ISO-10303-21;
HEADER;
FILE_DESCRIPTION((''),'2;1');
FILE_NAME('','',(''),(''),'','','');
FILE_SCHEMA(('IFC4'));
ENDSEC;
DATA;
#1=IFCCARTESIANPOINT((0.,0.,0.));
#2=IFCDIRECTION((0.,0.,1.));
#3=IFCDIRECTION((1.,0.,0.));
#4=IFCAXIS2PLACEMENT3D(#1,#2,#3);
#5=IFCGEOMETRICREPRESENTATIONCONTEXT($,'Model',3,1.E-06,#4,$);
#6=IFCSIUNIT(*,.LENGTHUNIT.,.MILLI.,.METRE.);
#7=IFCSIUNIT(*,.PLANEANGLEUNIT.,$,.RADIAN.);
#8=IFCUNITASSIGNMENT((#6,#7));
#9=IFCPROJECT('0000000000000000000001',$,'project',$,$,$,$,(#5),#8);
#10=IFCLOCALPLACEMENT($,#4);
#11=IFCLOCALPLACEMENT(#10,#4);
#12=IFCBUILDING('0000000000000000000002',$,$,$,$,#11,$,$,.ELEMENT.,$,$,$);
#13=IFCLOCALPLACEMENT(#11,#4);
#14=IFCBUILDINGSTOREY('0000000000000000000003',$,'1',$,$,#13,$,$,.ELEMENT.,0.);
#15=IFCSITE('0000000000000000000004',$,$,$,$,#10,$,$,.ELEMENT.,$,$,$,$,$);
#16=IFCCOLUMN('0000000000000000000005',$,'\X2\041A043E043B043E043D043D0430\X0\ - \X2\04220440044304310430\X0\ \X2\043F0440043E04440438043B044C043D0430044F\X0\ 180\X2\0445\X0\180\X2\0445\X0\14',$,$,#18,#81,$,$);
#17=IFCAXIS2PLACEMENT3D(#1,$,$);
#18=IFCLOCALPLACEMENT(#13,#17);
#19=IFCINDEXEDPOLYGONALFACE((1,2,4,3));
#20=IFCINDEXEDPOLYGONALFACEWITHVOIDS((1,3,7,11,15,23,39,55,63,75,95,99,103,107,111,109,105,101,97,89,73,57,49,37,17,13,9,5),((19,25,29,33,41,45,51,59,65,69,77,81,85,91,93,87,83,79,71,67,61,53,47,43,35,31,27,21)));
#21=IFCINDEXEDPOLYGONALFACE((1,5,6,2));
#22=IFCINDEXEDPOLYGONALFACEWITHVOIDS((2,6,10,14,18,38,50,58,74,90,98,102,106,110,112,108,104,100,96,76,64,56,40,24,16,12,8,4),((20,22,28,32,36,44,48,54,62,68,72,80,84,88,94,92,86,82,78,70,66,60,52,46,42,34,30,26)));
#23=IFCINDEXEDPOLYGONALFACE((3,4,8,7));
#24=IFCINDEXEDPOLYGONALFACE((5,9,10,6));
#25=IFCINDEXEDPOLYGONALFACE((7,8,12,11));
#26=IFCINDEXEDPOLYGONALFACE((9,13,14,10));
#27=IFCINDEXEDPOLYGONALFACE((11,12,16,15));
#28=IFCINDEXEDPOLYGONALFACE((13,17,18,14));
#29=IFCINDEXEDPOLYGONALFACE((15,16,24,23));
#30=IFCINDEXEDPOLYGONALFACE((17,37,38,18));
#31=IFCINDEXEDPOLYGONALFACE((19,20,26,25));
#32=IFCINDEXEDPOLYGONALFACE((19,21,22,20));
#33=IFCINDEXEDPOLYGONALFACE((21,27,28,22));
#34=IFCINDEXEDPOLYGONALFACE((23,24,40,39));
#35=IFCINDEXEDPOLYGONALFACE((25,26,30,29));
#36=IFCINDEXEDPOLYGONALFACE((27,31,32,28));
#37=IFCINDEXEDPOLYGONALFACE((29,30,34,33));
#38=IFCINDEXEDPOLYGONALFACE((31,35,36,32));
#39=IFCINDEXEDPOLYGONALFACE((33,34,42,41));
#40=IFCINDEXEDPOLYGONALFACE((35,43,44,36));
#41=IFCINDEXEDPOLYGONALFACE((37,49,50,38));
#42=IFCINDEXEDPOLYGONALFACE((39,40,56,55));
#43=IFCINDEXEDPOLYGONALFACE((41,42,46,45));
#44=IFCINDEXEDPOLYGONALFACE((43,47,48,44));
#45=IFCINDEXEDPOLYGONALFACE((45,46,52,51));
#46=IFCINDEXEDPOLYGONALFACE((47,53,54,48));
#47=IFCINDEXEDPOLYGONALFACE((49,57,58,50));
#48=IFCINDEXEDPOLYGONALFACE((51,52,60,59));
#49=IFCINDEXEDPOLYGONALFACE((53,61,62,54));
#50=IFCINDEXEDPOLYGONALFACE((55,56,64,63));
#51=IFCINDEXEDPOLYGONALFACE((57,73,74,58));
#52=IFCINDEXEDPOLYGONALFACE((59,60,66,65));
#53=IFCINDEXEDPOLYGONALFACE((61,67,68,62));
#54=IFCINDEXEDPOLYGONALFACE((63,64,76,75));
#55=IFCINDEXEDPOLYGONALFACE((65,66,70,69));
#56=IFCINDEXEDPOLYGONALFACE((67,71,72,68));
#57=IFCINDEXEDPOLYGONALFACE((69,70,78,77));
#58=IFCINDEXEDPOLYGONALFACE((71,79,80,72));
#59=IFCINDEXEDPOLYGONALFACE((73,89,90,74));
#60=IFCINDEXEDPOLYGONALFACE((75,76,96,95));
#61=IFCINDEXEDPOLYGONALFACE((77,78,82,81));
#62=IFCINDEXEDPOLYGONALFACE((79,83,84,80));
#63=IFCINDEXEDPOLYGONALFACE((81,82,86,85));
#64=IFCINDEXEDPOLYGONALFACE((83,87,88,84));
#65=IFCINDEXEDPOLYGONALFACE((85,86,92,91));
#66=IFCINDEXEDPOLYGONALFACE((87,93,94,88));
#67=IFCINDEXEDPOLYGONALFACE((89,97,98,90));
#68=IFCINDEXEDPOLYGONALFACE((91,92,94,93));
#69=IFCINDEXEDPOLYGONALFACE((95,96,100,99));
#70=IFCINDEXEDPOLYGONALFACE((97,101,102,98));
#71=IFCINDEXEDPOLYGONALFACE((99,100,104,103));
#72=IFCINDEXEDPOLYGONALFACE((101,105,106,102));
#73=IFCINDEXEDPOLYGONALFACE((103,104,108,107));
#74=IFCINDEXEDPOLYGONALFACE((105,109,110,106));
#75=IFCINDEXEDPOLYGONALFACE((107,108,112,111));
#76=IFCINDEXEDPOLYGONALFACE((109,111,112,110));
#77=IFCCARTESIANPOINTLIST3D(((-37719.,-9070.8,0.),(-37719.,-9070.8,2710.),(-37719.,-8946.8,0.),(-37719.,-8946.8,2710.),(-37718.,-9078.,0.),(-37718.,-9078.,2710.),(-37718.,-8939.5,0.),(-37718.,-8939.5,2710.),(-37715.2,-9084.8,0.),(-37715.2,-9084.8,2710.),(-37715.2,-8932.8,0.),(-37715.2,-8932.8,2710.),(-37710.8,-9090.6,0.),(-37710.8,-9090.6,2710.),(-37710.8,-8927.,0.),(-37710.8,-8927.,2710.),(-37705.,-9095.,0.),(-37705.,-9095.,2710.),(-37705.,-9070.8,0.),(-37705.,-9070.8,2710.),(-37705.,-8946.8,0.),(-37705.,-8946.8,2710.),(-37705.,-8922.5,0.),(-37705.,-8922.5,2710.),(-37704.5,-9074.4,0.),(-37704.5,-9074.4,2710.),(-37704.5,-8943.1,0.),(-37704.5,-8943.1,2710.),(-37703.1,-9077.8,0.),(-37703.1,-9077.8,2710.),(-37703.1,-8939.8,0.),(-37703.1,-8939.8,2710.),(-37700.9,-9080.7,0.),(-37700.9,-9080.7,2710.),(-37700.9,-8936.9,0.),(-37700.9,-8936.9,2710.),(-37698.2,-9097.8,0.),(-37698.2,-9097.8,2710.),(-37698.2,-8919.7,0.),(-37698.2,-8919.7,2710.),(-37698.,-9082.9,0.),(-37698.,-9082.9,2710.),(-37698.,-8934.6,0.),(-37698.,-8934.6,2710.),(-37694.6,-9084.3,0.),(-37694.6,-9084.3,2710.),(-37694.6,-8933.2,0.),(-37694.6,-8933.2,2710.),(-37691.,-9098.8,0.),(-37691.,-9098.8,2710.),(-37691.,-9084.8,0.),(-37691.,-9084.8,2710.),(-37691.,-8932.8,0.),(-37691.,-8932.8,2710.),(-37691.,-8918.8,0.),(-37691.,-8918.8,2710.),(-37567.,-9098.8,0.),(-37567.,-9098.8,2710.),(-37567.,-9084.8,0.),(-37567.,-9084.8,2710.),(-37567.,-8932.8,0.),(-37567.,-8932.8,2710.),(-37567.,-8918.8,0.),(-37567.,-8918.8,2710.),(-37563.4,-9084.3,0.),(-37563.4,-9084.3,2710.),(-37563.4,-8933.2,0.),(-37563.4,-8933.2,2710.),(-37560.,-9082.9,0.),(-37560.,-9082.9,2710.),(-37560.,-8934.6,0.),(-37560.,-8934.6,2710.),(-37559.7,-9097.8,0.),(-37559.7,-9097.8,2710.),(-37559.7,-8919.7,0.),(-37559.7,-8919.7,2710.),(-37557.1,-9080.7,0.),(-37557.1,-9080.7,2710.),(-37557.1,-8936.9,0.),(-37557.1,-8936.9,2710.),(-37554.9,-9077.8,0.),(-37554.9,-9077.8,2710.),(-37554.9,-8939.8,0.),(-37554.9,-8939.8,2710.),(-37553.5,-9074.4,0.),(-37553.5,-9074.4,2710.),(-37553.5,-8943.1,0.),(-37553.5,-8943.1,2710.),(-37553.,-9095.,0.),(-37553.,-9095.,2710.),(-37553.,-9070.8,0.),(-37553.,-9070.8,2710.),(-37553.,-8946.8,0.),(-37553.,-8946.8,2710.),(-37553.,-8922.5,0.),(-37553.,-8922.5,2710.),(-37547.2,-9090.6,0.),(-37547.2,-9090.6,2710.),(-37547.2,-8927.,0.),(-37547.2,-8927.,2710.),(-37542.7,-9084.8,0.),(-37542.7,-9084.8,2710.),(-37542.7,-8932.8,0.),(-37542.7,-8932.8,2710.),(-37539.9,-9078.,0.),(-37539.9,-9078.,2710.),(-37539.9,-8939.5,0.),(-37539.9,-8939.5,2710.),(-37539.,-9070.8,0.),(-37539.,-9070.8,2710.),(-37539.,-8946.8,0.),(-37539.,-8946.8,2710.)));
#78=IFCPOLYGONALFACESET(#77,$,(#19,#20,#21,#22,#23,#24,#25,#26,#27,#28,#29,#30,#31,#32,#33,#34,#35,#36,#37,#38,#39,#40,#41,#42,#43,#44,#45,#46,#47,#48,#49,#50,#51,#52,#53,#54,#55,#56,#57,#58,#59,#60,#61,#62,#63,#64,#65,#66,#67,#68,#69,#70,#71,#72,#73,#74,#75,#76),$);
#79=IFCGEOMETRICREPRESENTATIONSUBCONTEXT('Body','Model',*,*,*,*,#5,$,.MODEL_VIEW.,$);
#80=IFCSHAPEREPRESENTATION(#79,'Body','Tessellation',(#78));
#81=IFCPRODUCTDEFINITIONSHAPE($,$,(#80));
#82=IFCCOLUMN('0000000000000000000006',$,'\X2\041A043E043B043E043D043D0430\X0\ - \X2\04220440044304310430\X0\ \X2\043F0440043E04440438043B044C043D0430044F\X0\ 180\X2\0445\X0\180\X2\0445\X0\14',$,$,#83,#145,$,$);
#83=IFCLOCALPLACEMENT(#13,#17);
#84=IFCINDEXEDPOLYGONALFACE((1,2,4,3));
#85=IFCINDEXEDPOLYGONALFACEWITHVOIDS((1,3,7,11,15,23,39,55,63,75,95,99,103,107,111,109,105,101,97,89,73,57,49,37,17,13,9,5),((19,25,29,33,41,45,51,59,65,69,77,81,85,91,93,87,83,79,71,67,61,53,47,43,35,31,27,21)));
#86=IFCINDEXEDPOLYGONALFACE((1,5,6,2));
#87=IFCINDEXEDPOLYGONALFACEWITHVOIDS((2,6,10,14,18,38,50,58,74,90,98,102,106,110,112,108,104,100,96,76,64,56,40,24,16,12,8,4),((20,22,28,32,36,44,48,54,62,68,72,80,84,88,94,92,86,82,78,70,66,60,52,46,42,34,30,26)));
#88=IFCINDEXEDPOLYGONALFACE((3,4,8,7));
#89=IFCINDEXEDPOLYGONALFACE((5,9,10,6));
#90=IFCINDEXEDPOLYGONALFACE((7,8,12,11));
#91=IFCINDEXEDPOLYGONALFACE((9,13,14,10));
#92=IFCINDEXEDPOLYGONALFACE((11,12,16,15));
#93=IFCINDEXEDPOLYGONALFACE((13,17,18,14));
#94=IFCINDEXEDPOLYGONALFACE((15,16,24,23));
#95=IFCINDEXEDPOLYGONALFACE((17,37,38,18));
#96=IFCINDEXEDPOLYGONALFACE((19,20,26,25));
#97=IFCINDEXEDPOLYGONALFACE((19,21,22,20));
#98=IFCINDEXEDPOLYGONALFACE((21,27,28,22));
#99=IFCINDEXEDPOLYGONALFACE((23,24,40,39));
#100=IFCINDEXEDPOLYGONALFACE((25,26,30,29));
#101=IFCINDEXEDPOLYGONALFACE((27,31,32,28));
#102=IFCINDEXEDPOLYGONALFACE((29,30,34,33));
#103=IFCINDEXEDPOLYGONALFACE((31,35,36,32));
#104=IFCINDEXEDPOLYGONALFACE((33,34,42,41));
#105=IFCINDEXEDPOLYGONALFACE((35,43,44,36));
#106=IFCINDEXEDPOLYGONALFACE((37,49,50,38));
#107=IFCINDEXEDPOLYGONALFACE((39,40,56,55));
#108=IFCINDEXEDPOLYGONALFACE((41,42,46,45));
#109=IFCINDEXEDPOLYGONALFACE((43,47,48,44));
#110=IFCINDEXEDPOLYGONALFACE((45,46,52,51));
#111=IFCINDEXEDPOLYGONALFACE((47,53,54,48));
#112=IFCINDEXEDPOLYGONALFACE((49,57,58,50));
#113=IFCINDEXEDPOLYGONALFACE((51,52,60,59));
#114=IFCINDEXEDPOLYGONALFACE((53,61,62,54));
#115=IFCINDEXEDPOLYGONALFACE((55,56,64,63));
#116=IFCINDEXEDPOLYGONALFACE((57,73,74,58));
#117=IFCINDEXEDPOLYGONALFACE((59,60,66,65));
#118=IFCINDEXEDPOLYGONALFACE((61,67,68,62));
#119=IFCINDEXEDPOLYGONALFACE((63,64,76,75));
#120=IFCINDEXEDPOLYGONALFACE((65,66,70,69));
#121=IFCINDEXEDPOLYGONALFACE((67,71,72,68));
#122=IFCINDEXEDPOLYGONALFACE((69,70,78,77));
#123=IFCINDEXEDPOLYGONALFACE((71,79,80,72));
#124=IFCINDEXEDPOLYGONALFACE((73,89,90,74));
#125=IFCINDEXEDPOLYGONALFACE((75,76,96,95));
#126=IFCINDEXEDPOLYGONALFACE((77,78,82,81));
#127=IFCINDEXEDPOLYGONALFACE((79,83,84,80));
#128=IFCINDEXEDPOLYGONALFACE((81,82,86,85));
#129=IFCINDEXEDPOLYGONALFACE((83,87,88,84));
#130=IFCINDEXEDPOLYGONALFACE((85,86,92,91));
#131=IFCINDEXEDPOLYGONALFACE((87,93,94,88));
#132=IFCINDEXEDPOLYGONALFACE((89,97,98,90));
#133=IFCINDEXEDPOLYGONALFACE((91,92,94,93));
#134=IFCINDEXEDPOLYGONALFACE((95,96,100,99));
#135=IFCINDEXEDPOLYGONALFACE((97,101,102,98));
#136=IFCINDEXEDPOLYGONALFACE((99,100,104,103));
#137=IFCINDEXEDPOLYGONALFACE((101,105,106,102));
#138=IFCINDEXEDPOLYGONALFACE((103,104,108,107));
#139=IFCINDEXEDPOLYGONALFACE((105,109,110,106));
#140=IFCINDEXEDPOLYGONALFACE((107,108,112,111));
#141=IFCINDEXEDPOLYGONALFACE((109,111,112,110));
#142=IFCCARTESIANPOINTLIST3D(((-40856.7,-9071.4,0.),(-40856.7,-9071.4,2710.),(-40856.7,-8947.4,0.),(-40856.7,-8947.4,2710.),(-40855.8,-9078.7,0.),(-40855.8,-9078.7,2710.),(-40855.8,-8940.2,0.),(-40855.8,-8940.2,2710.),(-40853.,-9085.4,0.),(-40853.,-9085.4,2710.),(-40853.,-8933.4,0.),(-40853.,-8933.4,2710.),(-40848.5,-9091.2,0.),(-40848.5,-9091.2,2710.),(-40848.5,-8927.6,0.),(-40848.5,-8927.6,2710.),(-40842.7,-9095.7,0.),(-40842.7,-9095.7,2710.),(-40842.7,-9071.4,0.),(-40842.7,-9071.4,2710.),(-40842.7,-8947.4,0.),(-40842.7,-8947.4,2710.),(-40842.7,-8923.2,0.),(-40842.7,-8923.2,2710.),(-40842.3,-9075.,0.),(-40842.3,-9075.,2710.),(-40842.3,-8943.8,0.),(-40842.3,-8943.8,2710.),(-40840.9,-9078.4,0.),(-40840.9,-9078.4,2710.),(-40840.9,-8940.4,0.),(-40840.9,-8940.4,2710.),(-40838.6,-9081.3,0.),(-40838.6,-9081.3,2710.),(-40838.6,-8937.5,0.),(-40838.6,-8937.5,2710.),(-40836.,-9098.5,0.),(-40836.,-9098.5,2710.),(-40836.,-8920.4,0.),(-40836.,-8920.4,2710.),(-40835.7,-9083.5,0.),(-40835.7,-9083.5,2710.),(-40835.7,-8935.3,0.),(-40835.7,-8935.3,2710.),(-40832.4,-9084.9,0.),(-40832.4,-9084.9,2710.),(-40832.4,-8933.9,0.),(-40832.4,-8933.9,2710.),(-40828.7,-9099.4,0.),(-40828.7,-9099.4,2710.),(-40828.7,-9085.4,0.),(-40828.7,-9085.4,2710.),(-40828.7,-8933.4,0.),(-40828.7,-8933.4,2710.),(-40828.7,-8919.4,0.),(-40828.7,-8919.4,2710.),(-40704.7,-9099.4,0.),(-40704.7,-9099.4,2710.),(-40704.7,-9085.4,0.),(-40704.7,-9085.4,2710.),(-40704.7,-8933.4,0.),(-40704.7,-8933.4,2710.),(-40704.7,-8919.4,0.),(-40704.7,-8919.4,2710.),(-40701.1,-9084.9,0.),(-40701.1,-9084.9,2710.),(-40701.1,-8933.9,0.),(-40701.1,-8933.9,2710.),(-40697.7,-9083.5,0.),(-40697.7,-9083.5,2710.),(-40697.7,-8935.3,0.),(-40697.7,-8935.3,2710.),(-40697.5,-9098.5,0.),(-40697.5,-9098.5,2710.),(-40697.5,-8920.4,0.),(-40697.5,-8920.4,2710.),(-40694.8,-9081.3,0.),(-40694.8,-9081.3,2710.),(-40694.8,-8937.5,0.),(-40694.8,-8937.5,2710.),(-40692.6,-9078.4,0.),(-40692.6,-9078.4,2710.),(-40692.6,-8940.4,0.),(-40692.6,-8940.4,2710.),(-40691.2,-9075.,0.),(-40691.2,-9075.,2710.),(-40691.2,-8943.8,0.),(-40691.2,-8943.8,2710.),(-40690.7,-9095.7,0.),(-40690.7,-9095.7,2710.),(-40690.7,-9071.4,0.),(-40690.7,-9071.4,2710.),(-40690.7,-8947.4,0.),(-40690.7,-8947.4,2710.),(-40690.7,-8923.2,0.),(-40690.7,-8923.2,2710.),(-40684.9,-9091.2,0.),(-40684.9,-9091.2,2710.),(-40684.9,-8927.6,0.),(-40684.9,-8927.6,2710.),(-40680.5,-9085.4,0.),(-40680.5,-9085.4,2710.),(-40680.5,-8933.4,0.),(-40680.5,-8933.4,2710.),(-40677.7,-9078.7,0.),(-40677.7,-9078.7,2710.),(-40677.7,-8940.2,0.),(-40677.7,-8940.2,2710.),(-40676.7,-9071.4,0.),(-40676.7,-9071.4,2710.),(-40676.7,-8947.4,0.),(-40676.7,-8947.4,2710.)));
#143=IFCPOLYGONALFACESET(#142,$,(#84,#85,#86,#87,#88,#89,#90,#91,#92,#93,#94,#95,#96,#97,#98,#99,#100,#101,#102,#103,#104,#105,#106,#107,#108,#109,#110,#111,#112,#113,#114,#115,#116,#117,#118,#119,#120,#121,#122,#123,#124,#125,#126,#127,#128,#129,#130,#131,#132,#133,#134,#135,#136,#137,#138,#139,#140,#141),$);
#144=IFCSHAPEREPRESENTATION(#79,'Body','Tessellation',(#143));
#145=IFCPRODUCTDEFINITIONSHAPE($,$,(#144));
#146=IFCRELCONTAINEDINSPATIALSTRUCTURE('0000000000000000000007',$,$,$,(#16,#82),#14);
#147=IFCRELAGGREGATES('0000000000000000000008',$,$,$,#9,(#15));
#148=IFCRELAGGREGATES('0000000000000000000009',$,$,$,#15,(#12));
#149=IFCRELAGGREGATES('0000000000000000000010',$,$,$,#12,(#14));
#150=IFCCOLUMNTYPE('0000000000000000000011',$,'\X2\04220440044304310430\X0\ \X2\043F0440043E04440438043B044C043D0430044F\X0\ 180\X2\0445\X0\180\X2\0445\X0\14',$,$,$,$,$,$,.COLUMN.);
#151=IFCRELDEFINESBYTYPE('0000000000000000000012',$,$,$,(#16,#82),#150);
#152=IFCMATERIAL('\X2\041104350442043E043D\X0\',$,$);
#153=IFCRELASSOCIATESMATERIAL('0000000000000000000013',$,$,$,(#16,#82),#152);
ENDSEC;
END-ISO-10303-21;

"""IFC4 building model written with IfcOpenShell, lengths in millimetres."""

from ifc_helpers import new_model, si_unit, frame, origin_with_axes, place, context, subcontext, project, spatial, line, arc, indexed_curve, outline, extrude, source, transform, mapped, material, type_object, element, save


model = new_model("IFC4")

# Units and contexts
model_context = context("Model", 3, precision=1e-06, world=origin_with_axes())
body_context = subcontext(model_context, "Body", "Model", "MODEL_VIEW")
ifc_project = project(units=[si_unit("LENGTHUNIT", "METRE", prefix="MILLI"), si_unit("PLANEANGLEUNIT", "RADIAN")], contexts=[model_context])

# Site, building, storey
site_placement = place(None, origin_with_axes())
site = spatial("IfcSite", under=ifc_project, at=site_placement, CompositionType="ELEMENT")
building_placement = place(site_placement, origin_with_axes())
building = spatial("IfcBuilding", under=site, at=building_placement, CompositionType="ELEMENT")
storey_placement = place(building_placement, origin_with_axes())
storey = spatial("IfcBuildingStorey", under=building, at=storey_placement, Name="1", CompositionType="ELEMENT", Elevation=0.0)

# Columns
ifc_material = material(Name="Бетон")
column_type = type_object("IfcColumnType", Name="Труба профильная 180х180х14", PredefinedType="COLUMN")
shared_shape = source(origin_with_axes(), body_context, "Body", "SweptSolid", [
    extrude(outline(indexed_curve([(-90.0, -62.0), (-81.8, -81.8), (-62.0, -90.0), (62.0, -90.0), (81.8, -81.8), (90.0, -62.0), (90.0, 62.0), (81.8, 81.8), (62.0, 90.0), (-62.0, 90.0), (-81.8, 81.8), (-90.0, 62.0)], segments=[arc(1, 2, 3), line(3, 4), arc(4, 5, 6), line(6, 7), arc(7, 8, 9), line(9, 10), arc(10, 11, 12), line(12, 1)]), holes=[indexed_curve([(-76.0, 62.0), (-71.9, 71.9), (-62.0, 76.0), (62.0, 76.0), (71.9, 71.9), (76.0, 62.0), (76.0, -62.0), (71.9, -71.9), (62.0, -76.0), (-62.0, -76.0), (-71.9, -71.9), (-76.0, -62.0)], segments=[arc(1, 2, 3), line(3, 4), arc(4, 5, 6), line(6, 7), arc(7, 8, 9), line(9, 10), arc(10, 11, 12), line(12, 1)])]), origin_with_axes(), (0.0, 0.0, 1.0), 2710.0),
])
for number, where, z_axis, x_axis, name in (
    (1, (-37629.0, -9008.8, 0.0), (0.0, 0.0, 1.0), (1.0, 0.0, 0.0), "Колонна - Труба профильная 180х180х14"),
    (2, (-40766.7, -9009.4, 0.0), (0.0, 0.0, 1.0), (1.0, 0.0, 0.0), "Колонна - Труба профильная 180х180х14"),
):
    element("IfcColumn", number, at=place(storey_placement, frame(where, z_axis=z_axis, x_axis=x_axis)), inside=storey, type_object=column_type, material=ifc_material, Name=name, context=body_context, shape_type="MappedRepresentation", body=[
        mapped(shared_shape, transform((0.0, 0.0, 0.0), x_axis=(1.0, 0.0, 0.0), y_axis=(0.0, 1.0, 0.0), z_axis=(0.0, 0.0, 1.0), scale=1.0)),
    ])

save(model, "model.ifc")
